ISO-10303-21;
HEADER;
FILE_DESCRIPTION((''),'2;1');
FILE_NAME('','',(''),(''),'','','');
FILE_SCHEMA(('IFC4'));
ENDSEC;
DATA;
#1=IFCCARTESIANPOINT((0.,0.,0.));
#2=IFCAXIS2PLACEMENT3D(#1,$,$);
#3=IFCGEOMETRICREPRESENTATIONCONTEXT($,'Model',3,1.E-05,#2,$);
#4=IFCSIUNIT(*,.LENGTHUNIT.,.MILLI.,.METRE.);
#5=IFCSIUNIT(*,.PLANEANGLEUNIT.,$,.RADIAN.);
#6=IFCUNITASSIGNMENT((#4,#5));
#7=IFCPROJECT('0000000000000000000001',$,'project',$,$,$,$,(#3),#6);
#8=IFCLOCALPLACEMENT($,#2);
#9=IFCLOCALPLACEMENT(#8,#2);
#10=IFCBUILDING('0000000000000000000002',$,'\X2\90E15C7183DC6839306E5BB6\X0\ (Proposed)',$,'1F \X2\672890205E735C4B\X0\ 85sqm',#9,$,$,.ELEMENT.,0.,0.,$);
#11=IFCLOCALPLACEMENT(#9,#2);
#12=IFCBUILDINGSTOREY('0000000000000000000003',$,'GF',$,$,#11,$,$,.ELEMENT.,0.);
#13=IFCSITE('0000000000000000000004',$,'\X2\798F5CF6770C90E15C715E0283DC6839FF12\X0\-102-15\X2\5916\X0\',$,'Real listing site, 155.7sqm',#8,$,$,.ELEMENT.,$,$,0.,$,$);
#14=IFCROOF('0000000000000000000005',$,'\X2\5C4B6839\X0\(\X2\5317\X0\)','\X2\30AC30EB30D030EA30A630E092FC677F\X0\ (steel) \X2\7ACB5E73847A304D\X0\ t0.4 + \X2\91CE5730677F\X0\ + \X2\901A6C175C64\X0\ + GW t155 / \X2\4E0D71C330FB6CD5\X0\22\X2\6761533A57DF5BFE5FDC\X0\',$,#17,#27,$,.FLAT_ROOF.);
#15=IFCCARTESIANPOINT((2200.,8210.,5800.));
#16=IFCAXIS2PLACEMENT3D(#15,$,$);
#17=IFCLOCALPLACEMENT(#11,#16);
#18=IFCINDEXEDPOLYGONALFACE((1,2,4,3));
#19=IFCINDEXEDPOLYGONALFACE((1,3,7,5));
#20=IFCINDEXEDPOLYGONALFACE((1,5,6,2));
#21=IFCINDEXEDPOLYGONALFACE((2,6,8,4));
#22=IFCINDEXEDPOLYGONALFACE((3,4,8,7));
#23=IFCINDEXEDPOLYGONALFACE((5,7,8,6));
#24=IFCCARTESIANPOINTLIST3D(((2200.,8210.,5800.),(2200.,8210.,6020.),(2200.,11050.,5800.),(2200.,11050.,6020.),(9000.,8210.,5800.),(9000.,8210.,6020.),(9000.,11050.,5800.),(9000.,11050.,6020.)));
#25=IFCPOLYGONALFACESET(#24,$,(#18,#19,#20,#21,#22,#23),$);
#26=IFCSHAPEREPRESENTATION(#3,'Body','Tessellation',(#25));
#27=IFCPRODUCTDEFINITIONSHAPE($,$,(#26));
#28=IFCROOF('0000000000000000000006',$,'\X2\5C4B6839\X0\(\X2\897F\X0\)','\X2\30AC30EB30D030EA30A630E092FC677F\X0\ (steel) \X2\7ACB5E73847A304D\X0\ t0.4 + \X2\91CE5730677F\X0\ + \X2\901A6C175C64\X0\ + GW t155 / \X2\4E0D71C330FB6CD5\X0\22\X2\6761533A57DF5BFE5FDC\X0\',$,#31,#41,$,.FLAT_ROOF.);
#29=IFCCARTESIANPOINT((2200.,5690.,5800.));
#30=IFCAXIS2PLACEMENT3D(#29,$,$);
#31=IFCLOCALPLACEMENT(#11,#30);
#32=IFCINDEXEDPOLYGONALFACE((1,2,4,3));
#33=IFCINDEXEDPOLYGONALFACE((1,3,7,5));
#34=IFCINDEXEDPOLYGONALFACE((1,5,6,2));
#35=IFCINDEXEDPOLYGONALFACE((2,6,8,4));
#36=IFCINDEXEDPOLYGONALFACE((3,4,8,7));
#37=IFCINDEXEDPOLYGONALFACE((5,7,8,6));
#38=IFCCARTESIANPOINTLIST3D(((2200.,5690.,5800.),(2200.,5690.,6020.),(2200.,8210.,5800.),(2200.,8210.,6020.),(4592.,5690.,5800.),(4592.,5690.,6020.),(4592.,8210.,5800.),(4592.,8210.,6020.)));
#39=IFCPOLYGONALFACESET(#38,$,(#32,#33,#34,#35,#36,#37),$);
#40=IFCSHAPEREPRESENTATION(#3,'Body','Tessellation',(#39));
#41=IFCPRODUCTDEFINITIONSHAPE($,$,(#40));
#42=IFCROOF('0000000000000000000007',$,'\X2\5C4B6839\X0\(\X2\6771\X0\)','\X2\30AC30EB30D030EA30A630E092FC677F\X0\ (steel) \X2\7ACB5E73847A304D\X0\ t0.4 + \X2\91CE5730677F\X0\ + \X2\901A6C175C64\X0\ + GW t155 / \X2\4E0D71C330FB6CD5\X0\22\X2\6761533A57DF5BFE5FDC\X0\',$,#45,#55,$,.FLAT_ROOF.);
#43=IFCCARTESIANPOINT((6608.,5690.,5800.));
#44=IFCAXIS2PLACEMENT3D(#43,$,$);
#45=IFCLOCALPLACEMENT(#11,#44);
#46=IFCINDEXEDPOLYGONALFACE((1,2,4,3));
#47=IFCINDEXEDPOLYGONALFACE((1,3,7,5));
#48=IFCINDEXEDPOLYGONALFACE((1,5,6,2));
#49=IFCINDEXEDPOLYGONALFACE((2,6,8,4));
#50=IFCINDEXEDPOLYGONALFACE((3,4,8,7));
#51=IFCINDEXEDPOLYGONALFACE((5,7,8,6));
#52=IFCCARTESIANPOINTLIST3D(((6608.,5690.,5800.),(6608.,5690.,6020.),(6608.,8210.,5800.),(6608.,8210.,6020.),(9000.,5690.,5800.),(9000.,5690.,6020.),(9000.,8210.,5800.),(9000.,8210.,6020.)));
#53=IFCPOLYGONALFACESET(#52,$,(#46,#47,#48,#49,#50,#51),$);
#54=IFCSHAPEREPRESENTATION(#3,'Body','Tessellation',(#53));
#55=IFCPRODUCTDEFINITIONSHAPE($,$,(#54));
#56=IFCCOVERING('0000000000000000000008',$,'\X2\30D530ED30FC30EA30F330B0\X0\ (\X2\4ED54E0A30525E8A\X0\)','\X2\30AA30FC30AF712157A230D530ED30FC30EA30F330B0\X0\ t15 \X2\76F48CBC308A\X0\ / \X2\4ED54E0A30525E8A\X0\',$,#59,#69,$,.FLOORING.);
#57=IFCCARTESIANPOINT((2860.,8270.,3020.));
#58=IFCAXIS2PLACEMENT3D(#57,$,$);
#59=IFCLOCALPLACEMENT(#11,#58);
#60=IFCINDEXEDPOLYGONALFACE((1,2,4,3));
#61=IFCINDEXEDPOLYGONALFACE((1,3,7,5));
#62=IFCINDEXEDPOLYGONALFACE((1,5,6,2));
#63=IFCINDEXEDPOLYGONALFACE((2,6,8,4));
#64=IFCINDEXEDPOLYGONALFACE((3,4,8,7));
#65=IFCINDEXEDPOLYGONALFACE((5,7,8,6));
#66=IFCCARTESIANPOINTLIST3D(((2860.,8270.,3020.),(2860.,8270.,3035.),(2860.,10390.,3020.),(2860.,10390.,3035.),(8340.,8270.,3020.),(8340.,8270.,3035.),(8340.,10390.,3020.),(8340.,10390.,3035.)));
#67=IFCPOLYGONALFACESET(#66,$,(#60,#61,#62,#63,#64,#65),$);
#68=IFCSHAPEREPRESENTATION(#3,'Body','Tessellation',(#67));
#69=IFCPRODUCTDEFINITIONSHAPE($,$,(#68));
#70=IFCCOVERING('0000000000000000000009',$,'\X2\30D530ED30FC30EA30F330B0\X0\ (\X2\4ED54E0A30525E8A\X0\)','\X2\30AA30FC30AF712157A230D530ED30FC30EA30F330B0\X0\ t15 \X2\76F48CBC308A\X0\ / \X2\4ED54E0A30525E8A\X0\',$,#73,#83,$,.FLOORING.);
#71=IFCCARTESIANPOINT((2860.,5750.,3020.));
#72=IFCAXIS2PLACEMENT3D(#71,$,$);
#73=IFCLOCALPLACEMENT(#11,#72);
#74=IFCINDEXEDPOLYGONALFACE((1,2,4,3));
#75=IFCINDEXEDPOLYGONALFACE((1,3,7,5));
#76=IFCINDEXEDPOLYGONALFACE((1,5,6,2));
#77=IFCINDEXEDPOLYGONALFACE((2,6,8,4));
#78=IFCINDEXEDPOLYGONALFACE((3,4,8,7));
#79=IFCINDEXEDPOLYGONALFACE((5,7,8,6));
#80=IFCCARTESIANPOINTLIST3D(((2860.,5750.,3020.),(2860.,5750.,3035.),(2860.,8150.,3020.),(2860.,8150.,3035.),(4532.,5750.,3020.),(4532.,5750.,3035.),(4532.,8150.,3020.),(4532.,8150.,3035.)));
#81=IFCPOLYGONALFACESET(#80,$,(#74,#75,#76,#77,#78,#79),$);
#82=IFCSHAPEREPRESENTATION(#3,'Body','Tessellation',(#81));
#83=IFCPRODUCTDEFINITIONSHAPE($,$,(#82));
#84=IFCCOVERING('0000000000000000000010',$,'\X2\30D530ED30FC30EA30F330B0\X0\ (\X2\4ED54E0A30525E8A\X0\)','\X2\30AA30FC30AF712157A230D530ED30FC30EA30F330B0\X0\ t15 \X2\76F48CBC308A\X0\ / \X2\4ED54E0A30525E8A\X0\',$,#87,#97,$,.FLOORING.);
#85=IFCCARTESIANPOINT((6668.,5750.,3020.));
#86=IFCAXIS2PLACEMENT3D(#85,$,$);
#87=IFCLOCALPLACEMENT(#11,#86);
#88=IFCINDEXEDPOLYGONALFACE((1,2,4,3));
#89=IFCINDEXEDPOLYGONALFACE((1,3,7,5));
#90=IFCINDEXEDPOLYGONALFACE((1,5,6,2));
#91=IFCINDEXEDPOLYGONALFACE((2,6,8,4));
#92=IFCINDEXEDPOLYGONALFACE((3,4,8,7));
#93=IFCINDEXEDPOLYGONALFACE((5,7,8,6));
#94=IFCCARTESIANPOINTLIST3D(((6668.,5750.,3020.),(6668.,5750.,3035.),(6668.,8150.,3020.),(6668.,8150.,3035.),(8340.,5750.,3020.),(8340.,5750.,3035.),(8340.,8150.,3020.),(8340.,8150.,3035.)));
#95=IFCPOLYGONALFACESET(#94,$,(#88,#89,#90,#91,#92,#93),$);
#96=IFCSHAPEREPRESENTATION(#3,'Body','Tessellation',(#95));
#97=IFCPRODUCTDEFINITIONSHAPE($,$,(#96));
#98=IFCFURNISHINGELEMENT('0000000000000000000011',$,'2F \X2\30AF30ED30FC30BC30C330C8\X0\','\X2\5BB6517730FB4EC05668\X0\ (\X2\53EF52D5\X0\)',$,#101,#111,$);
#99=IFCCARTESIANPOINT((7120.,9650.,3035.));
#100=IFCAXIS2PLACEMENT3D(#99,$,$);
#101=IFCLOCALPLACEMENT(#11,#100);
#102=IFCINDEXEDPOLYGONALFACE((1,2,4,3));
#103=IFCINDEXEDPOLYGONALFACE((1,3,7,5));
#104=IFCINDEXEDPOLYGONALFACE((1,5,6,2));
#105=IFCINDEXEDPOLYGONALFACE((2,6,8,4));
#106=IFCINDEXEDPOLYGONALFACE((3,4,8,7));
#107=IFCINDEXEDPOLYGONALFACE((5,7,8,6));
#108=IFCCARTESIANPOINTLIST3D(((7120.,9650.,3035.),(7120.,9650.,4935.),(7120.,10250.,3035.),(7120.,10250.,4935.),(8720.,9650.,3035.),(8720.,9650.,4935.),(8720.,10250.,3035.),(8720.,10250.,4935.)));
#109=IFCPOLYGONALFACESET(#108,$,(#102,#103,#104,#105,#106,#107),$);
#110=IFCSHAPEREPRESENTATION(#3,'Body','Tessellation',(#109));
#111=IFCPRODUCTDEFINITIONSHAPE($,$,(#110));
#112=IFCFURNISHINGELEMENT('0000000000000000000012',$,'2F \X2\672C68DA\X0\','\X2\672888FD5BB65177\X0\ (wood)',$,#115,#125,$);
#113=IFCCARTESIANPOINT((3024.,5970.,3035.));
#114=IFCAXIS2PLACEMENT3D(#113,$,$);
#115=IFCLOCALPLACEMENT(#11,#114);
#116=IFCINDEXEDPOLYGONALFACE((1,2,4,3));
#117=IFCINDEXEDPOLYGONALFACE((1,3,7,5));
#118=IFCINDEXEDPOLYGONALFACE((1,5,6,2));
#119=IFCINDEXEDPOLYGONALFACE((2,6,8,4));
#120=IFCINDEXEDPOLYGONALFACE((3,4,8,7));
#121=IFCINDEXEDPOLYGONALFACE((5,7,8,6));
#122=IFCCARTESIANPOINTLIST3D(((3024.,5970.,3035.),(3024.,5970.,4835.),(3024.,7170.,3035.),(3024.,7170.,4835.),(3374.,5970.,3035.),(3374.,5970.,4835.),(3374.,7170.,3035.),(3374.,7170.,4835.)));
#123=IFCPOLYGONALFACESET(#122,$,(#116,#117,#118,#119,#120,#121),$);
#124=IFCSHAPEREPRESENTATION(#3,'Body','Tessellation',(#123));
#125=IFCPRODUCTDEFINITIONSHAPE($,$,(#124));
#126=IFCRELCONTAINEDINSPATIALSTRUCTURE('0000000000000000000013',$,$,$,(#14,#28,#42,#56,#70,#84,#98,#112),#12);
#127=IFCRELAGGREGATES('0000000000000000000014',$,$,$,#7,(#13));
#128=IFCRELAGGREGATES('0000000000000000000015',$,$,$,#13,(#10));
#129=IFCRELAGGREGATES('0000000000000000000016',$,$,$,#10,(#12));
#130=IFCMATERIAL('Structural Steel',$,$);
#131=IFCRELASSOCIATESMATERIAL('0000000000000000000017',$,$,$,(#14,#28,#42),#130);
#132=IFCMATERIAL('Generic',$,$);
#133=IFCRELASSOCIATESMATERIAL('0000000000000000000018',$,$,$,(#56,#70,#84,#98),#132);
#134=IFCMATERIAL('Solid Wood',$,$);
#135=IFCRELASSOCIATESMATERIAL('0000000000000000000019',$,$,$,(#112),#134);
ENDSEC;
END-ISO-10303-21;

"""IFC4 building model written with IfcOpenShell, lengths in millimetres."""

from ifc_helpers import new_model, si_unit, frame, frame_2d, origin, place, context, project, spatial, rectangle, extrude, material, element, save


model = new_model("IFC4")

# Units and contexts
model_context = context("Model", 3, precision=1e-05, world=origin())
ifc_project = project(units=[si_unit("LENGTHUNIT", "METRE", prefix="MILLI"), si_unit("PLANEANGLEUNIT", "RADIAN")], contexts=[model_context])

# Site, building, storey
site_placement = place(None, origin())
site = spatial("IfcSite", under=ifc_project, at=site_placement, Name="福島県郡山市菜根２-102-15外", ObjectType="Real listing site, 155.7sqm", CompositionType="ELEMENT", RefElevation=0.0)
building_placement = place(site_placement, origin())
building = spatial("IfcBuilding", under=site, at=building_placement, Name="郡山菜根の家 (Proposed)", ObjectType="1F 木造平屋 85sqm", CompositionType="ELEMENT", ElevationOfRefHeight=0.0, ElevationOfTerrain=0.0)
storey_placement = place(building_placement, origin())
storey = spatial("IfcBuildingStorey", under=building, at=storey_placement, Name="GF", CompositionType="ELEMENT", Elevation=0.0)

# Shared definitions
ifc_material_1 = material(Name="Solid Wood")

# Shared definitions
ifc_material_2 = material(Name="Generic")

# Roofs
ifc_material_3 = material(Name="Structural Steel")
for number, where, name in (
    (1, (2200.0, 8210.0, 5800.0), "屋根(北)"),
):
    element("IfcRoof", number, at=place(storey_placement, frame(where)), inside=storey, material=ifc_material_3, Name=name, Description="ガルバリウム鋼板 (steel) 立平葺き t0.4 + 野地板 + 通気層 + GW t155 / 不燃・法22条区域対応", PredefinedType="FLAT_ROOF", context=model_context, shape_type="SweptSolid", body=[
        extrude(rectangle(XDim=6800.0, YDim=2840.0, at=frame_2d((3400.0, 1420.0))), frame((2200.0, 8210.0, 5800.0)), (0.0, 0.0, 1.0), 220.0),
    ])
roof_1_placement = place(storey_placement, frame((2200.0, 5690.0, 5800.0)))
element("IfcRoof", 2, at=roof_1_placement, inside=storey, material=ifc_material_3, Name="屋根(西)", Description="ガルバリウム鋼板 (steel) 立平葺き t0.4 + 野地板 + 通気層 + GW t155 / 不燃・法22条区域対応", PredefinedType="FLAT_ROOF", context=model_context, shape_type="SweptSolid", body=[
    extrude(rectangle(XDim=2392.0, YDim=2520.0, at=frame_2d((1196.0, 1260.0))), frame((2200.0, 5690.0, 5800.0)), (0.0, 0.0, 1.0), 220.0),
])
roof_2_placement = place(storey_placement, frame((6608.0, 5690.0, 5800.0)))
element("IfcRoof", 3, at=roof_2_placement, inside=storey, material=ifc_material_3, Name="屋根(東)", Description="ガルバリウム鋼板 (steel) 立平葺き t0.4 + 野地板 + 通気層 + GW t155 / 不燃・法22条区域対応", PredefinedType="FLAT_ROOF", context=model_context, shape_type="SweptSolid", body=[
    extrude(rectangle(XDim=2392.0, YDim=2520.0, at=frame_2d((1196.0, 1260.0))), frame((6608.0, 5690.0, 5800.0)), (0.0, 0.0, 1.0), 220.0),
])

# Coverings
covering_1_placement = place(storey_placement, frame((2860.0, 8270.0, 3020.0)))
element("IfcCovering", 4, at=covering_1_placement, inside=storey, material=ifc_material_2, Name="フローリング (仕上げ床)", Description="オーク無垢フローリング t15 直貼り / 仕上げ床", PredefinedType="FLOORING", context=model_context, shape_type="SweptSolid", body=[
    extrude(rectangle(XDim=5480.0, YDim=2120.0, at=frame_2d((2740.0, 1060.0))), frame((2860.0, 8270.0, 3020.0)), (0.0, 0.0, 1.0), 15.0),
])
covering_2_placement = place(storey_placement, frame((2860.0, 5750.0, 3020.0)))
element("IfcCovering", 5, at=covering_2_placement, inside=storey, material=ifc_material_2, Name="フローリング (仕上げ床)", Description="オーク無垢フローリング t15 直貼り / 仕上げ床", PredefinedType="FLOORING", context=model_context, shape_type="SweptSolid", body=[
    extrude(rectangle(XDim=1672.0, YDim=2400.0, at=frame_2d((836.0, 1200.0))), frame((2860.0, 5750.0, 3020.0)), (0.0, 0.0, 1.0), 15.0),
])
covering_3_placement = place(storey_placement, frame((6668.0, 5750.0, 3020.0)))
element("IfcCovering", 6, at=covering_3_placement, inside=storey, material=ifc_material_2, Name="フローリング (仕上げ床)", Description="オーク無垢フローリング t15 直貼り / 仕上げ床", PredefinedType="FLOORING", context=model_context, shape_type="SweptSolid", body=[
    extrude(rectangle(XDim=1672.0, YDim=2400.0, at=frame_2d((836.0, 1200.0))), frame((6668.0, 5750.0, 3020.0)), (0.0, 0.0, 1.0), 15.0),
])

# Furnishing elements
furnishing_1_placement = place(storey_placement, frame((7120.0, 9650.0, 3035.0)))
element("IfcFurnishingElement", 7, at=furnishing_1_placement, inside=storey, material=ifc_material_2, Name="2F クローゼット", Description="家具・什器 (可動)", context=model_context, shape_type="SweptSolid", body=[
    extrude(rectangle(XDim=1600.0, YDim=600.0, at=frame_2d((800.0, 300.0))), frame((7120.0, 9650.0, 3035.0)), (0.0, 0.0, 1.0), 1900.0),
])
furnishing_2_placement = place(storey_placement, frame((3024.0, 5970.0, 3035.0)))
element("IfcFurnishingElement", 8, at=furnishing_2_placement, inside=storey, material=ifc_material_1, Name="2F 本棚", Description="木製家具 (wood)", context=model_context, shape_type="SweptSolid", body=[
    extrude(rectangle(XDim=350.0, YDim=1200.0, at=frame_2d((175.0, 600.0))), frame((3024.0, 5970.0, 3035.0)), (0.0, 0.0, 1.0), 1800.0),
])

save(model, "model.ifc")
